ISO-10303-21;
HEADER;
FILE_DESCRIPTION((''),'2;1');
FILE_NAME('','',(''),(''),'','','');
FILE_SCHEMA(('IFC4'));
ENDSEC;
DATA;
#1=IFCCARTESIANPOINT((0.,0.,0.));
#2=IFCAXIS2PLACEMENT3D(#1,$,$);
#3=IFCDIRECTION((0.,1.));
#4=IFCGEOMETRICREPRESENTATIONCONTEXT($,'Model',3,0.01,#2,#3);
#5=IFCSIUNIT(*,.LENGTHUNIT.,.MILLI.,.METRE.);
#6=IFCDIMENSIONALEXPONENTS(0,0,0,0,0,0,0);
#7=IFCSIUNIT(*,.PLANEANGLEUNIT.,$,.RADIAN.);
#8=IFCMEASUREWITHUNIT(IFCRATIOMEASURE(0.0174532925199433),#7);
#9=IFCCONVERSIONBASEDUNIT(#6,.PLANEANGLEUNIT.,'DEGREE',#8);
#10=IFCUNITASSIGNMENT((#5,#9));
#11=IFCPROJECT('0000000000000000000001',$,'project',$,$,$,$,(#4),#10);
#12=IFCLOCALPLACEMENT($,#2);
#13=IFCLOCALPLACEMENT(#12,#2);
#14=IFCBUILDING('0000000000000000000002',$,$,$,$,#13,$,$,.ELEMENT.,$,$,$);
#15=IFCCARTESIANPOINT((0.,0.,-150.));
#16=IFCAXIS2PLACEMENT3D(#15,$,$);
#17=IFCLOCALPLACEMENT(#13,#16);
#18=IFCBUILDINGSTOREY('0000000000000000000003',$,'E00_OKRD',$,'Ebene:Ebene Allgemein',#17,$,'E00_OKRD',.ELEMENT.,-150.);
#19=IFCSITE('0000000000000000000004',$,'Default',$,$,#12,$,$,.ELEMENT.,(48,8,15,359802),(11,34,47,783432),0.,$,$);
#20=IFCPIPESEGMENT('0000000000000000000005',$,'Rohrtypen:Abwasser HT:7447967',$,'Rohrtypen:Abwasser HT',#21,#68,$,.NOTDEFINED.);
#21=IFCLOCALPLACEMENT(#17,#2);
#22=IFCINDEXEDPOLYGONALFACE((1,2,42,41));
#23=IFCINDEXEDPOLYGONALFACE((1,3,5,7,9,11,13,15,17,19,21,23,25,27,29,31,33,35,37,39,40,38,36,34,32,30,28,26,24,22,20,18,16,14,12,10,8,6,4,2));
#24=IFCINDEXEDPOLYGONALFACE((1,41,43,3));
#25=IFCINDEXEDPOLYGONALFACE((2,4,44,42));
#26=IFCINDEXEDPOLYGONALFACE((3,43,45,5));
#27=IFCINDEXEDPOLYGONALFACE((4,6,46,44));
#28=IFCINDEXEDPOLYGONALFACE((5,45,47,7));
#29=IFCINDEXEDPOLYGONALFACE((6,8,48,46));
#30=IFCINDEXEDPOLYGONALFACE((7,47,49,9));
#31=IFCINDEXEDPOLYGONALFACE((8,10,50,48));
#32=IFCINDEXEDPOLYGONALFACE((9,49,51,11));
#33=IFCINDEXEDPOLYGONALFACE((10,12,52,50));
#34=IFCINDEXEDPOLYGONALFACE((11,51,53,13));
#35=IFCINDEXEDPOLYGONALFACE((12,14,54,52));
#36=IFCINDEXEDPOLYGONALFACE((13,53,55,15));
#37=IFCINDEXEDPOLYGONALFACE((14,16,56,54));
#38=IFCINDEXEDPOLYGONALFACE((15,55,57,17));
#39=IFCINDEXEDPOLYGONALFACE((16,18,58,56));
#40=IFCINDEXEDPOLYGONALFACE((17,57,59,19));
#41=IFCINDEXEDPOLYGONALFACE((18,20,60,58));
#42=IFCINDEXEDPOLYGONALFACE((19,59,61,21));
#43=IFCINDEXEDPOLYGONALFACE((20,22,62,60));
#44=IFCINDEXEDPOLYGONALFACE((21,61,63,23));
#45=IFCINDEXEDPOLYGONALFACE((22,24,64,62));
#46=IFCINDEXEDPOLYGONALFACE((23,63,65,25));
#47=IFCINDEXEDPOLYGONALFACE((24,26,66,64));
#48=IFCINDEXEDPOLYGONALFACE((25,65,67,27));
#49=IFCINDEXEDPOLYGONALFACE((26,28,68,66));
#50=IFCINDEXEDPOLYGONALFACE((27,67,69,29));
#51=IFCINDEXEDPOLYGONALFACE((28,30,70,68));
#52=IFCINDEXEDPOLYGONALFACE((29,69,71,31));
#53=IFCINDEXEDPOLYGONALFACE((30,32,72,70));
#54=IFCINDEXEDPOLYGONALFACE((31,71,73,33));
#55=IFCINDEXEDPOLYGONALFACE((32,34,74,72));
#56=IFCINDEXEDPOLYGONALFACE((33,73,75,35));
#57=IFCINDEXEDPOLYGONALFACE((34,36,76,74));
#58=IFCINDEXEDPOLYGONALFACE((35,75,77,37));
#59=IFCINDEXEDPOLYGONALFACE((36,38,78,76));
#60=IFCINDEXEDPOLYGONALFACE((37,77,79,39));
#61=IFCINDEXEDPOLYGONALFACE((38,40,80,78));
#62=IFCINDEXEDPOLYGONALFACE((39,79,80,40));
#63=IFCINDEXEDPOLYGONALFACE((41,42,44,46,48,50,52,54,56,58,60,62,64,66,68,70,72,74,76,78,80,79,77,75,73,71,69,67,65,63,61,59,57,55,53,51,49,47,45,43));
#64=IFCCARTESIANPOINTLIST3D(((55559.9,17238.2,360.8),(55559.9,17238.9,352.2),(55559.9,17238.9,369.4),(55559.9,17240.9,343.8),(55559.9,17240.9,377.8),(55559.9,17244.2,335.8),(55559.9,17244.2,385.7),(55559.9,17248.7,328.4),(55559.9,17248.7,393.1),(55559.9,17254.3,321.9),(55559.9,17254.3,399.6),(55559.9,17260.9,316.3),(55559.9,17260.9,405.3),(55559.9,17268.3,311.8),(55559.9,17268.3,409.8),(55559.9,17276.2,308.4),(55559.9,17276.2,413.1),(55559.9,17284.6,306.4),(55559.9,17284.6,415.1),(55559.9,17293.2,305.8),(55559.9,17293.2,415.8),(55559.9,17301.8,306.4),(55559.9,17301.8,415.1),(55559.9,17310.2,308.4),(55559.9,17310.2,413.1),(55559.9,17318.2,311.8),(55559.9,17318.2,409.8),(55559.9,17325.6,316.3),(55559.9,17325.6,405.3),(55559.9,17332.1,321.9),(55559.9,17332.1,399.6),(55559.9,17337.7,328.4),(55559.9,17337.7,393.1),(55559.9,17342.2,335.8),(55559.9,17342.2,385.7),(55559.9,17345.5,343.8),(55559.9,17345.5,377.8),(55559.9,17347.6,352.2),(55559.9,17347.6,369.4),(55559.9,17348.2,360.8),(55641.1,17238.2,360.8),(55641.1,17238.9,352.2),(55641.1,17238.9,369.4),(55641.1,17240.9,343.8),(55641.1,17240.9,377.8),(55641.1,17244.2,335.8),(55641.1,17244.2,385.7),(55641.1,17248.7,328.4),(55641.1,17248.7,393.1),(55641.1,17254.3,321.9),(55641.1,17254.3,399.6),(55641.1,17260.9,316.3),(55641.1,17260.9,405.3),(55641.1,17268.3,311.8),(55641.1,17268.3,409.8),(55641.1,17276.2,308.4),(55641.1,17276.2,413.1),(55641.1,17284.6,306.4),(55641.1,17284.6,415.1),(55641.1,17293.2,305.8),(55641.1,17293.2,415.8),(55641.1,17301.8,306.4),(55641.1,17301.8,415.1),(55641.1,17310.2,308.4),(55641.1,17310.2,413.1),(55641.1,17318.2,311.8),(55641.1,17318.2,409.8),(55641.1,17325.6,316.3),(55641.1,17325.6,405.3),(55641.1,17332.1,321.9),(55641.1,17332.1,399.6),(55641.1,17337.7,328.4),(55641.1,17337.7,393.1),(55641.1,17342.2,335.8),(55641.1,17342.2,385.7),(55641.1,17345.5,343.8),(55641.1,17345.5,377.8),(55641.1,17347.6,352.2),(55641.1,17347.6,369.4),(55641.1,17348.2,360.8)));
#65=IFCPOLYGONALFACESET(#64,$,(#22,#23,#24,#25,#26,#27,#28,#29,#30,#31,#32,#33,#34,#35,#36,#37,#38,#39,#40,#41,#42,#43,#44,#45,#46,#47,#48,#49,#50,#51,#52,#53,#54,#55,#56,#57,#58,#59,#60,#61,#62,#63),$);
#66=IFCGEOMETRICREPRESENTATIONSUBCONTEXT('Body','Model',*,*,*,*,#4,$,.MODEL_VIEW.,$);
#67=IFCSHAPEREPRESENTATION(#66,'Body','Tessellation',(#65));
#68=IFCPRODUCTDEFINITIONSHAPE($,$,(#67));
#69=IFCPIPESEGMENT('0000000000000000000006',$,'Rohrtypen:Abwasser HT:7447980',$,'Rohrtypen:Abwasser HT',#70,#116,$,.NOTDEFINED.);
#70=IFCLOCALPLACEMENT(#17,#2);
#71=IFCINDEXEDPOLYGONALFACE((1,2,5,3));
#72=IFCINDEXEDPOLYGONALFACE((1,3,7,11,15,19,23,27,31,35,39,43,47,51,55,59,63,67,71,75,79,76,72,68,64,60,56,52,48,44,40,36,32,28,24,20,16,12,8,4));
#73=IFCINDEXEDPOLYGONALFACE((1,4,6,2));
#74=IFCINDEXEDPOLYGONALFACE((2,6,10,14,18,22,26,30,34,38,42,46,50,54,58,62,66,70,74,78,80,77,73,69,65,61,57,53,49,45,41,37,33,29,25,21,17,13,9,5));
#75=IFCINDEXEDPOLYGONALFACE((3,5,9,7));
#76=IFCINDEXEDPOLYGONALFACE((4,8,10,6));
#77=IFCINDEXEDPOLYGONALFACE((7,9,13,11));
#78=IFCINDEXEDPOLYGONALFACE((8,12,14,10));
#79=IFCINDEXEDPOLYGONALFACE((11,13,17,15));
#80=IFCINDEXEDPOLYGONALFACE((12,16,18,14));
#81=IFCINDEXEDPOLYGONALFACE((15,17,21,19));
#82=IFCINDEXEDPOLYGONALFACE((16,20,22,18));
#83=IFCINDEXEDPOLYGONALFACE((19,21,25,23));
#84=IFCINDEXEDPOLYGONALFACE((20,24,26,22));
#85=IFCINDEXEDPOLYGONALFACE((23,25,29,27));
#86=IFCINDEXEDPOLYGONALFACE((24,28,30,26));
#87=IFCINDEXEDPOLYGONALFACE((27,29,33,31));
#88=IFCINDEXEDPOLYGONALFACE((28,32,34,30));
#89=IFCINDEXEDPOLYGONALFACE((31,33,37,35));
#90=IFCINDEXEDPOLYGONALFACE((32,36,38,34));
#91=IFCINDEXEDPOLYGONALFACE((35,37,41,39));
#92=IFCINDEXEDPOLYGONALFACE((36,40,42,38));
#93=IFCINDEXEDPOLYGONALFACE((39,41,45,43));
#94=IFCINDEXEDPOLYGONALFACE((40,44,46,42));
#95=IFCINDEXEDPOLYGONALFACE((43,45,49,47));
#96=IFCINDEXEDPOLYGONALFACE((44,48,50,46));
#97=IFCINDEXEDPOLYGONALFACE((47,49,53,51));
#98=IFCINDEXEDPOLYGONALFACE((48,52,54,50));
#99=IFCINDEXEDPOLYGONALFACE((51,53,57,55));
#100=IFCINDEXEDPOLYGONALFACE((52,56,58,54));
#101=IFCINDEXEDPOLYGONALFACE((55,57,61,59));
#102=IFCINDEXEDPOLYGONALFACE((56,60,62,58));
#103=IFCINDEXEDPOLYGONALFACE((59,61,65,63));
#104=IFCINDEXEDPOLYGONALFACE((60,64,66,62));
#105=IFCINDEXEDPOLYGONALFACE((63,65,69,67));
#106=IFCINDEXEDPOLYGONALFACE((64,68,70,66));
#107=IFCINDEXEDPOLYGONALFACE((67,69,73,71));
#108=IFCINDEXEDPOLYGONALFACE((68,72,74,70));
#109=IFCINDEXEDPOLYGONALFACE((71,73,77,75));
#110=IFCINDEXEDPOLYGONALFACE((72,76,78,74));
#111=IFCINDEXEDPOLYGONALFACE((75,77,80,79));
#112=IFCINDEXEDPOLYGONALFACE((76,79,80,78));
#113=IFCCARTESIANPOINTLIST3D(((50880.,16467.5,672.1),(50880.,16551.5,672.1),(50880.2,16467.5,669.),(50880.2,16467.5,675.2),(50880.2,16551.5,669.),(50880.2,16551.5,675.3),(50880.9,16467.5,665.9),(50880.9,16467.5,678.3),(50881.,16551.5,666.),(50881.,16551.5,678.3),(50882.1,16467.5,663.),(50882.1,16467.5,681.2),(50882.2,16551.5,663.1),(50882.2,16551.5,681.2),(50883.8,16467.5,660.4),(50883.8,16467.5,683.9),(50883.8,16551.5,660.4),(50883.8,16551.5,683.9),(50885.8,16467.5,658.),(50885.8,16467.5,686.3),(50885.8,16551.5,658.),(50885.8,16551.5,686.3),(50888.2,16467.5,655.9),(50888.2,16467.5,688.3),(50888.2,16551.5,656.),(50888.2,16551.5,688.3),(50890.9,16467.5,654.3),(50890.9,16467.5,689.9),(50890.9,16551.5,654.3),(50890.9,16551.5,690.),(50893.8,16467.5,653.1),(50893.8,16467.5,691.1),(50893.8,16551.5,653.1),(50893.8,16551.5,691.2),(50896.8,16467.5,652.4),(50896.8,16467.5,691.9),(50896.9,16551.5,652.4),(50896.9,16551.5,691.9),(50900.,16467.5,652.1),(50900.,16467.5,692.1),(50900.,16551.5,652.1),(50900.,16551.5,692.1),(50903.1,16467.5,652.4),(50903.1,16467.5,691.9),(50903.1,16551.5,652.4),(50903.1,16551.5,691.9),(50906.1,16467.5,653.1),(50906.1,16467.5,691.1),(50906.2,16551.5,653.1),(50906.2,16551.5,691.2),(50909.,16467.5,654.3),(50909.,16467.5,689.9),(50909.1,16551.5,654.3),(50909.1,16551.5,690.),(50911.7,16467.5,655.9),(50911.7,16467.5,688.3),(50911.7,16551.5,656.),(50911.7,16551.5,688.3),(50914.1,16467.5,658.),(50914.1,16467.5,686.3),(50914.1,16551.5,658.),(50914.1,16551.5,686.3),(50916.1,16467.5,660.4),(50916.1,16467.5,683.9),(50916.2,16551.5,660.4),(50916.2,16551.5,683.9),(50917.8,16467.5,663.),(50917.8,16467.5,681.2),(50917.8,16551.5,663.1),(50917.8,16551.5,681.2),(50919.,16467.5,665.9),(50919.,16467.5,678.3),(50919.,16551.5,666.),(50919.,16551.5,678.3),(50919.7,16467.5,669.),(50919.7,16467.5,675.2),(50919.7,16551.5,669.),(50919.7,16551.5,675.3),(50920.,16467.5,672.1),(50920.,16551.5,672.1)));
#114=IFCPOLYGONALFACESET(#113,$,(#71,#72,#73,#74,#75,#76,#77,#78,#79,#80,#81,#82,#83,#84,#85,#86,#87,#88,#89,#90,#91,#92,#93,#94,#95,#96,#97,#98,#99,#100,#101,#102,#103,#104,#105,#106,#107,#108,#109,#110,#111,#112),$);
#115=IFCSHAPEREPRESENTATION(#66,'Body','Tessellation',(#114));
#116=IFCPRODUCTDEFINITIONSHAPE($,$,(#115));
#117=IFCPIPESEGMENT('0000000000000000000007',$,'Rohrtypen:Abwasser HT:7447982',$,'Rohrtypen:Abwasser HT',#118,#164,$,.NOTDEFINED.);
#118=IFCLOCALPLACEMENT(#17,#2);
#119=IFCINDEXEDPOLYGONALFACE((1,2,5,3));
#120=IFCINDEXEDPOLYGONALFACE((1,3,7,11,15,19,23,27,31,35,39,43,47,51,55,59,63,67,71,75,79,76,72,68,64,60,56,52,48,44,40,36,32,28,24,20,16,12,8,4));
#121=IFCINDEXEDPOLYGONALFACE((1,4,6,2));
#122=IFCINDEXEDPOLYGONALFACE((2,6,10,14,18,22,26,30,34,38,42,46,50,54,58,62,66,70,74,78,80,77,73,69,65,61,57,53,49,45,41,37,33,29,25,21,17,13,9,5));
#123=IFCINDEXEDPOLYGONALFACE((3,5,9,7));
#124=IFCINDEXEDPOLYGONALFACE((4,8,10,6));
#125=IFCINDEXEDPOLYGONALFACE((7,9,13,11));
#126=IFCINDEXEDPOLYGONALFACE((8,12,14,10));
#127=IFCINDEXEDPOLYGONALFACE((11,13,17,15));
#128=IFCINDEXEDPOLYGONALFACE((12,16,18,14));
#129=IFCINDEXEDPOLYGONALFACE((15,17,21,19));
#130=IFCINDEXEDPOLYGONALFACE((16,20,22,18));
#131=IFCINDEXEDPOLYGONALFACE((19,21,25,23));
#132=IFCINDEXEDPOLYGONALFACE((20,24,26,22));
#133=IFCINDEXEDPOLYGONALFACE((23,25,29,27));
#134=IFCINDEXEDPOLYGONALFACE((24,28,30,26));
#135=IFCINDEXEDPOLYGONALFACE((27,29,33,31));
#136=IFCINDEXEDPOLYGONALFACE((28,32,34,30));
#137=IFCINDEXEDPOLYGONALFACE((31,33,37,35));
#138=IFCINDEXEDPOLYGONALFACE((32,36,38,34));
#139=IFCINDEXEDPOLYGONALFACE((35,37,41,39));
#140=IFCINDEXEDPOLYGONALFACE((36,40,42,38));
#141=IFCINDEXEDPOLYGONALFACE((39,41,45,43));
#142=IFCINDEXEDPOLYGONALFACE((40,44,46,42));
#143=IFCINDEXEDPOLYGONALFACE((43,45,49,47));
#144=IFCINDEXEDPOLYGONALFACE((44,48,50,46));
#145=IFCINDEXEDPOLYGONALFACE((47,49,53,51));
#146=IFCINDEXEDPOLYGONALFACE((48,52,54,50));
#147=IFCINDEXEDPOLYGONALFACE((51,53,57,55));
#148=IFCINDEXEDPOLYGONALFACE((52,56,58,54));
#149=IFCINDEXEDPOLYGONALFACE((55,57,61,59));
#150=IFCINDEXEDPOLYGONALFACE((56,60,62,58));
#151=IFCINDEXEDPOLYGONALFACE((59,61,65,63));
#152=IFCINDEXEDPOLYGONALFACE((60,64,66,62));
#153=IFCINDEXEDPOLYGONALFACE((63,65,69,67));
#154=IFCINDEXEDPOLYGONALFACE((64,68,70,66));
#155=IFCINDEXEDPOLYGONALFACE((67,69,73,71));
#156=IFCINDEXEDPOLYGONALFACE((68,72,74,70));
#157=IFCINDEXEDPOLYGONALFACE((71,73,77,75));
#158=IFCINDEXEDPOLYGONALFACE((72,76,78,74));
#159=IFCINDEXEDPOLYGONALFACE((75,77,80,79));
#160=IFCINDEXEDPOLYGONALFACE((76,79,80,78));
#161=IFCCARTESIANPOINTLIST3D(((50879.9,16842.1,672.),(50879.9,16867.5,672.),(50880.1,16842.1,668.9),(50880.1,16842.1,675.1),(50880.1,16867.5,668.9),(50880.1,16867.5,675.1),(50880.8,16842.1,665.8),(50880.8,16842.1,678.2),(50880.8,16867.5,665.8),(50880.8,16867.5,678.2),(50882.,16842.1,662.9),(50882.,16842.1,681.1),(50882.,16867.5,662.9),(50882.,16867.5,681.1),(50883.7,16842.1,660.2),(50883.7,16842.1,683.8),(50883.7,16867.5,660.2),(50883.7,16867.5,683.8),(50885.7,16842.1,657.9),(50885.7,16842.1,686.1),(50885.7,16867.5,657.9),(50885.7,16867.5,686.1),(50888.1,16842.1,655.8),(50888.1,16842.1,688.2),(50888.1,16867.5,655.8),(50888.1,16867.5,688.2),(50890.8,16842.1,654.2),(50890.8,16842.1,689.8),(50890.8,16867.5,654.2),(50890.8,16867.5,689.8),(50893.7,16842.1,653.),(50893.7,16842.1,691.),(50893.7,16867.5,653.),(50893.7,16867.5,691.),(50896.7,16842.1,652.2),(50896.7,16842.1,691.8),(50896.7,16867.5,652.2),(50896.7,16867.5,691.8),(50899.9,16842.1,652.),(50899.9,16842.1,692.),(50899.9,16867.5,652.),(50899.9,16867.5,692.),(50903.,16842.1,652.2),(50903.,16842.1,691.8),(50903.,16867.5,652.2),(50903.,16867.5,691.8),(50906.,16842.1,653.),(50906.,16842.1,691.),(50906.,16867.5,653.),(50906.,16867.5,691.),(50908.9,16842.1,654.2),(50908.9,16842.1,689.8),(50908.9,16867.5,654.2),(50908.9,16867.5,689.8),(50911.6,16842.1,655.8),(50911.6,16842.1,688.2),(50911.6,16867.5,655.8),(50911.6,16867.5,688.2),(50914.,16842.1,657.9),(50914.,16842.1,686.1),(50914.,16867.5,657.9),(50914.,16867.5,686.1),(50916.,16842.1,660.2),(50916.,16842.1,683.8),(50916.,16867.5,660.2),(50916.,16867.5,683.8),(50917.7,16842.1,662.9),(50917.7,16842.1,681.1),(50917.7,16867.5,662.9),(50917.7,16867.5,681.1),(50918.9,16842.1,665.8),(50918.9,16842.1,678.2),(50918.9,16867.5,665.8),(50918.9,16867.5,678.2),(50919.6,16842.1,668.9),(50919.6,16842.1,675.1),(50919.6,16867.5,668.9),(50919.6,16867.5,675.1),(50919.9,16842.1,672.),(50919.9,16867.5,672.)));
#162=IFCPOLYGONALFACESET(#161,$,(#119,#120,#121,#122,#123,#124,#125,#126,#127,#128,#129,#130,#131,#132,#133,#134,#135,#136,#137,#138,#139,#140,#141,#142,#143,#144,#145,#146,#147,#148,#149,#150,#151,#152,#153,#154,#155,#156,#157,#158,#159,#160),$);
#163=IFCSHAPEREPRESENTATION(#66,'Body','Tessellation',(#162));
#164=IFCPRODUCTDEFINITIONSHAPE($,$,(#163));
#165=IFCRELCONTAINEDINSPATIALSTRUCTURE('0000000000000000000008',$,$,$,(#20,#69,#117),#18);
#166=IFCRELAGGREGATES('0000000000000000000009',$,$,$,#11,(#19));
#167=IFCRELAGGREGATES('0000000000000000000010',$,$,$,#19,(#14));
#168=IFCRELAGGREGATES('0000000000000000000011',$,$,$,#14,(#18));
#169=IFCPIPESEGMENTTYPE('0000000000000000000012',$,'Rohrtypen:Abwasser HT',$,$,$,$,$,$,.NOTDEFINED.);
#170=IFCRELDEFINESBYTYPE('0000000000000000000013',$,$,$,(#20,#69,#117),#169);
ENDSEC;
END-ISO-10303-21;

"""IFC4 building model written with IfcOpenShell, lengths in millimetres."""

from ifc_helpers import new_model, entity, si_unit, converted_unit, direction, frame, origin, place, context, subcontext, project, spatial, indexed_curve, outline, extrude, type_object, element, save


model = new_model("IFC4")

# Units and contexts
model_context = context("Model", 3, precision=0.01, world=origin(), true_north=direction((0.0, 1.0)))
body_context = subcontext(model_context, "Body", "Model", "MODEL_VIEW")
ifc_project = project(units=[si_unit("LENGTHUNIT", "METRE", prefix="MILLI"), converted_unit("PLANEANGLEUNIT", "DEGREE", entity("IfcRatioMeasure", 0.0174532925199433), si_unit("PLANEANGLEUNIT", "RADIAN"), dimensions=[0, 0, 0, 0, 0, 0, 0])], contexts=[model_context])

# Site, building, storey
site_placement = place(None, origin())
site = spatial("IfcSite", under=ifc_project, at=site_placement, Name="Default", CompositionType="ELEMENT", RefLatitude=(48, 8, 15, 359802), RefLongitude=(11, 34, 47, 783432), RefElevation=0.0)
building_placement = place(site_placement, origin())
building = spatial("IfcBuilding", under=site, at=building_placement, CompositionType="ELEMENT")
storey_placement = place(building_placement, frame((0.0, 0.0, -150.0)))
storey = spatial("IfcBuildingStorey", under=building, at=storey_placement, Name="E00_OKRD", ObjectType="Ebene:Ebene Allgemein", LongName="E00_OKRD", CompositionType="ELEMENT", Elevation=-150.0)

# Pipe segments
pipe_segment_type_1 = type_object("IfcPipeSegmentType", Name="Rohrtypen:Abwasser HT", PredefinedType="NOTDEFINED")
pipe_segment_1_placement = place(storey_placement, origin())
element("IfcPipeSegment", 1, at=pipe_segment_1_placement, inside=storey, type_object=pipe_segment_type_1, Name="Rohrtypen:Abwasser HT:7447967", ObjectType="Rohrtypen:Abwasser HT", PredefinedType="NOTDEFINED", context=body_context, shape_type="SweptSolid", body=[
    extrude(outline(indexed_curve([(55.0, 0.0), (54.3, 8.6), (52.3, 17.0), (49.0, 25.0), (44.5, 32.3), (38.9, 38.9), (32.3, 44.5), (25.0, 49.0), (17.0, 52.3), (8.6, 54.3), (0.0, 55.0), (-8.6, 54.3), (-17.0, 52.3), (-25.0, 49.0), (-32.3, 44.5), (-38.9, 38.9), (-44.5, 32.3), (-49.0, 25.0), (-52.3, 17.0), (-54.3, 8.6), (-55.0, 0.0), (-54.3, -8.6), (-52.3, -17.0), (-49.0, -25.0), (-44.5, -32.3), (-38.9, -38.9), (-32.3, -44.5), (-25.0, -49.0), (-17.0, -52.3), (-8.6, -54.3), (0.0, -55.0), (8.6, -54.3), (17.0, -52.3), (25.0, -49.0), (32.3, -44.5), (38.9, -38.9), (44.5, -32.3), (49.0, -25.0), (52.3, -17.0), (54.3, -8.6), (55.0, 0.0)], self_intersect=False)), frame((55559.9, 17293.2, 360.8), z_axis=(1.0, 0.0, 0.0), x_axis=(0.0, -1.0, 0.0)), (0.0, 0.0, 1.0), 81.3),
])
pipe_segment_2_placement = place(storey_placement, origin())
element("IfcPipeSegment", 2, at=pipe_segment_2_placement, inside=storey, type_object=pipe_segment_type_1, Name="Rohrtypen:Abwasser HT:7447980", ObjectType="Rohrtypen:Abwasser HT", PredefinedType="NOTDEFINED", context=body_context, shape_type="SweptSolid", body=[
    extrude(outline(indexed_curve([(20.0, 0.0), (19.8, 3.1), (19.0, 6.2), (17.8, 9.1), (16.2, 11.8), (14.1, 14.1), (11.8, 16.2), (9.1, 17.8), (6.2, 19.0), (3.1, 19.8), (0.0, 20.0), (-3.1, 19.8), (-6.2, 19.0), (-9.1, 17.8), (-11.8, 16.2), (-14.1, 14.1), (-16.2, 11.8), (-17.8, 9.1), (-19.0, 6.2), (-19.8, 3.1), (-20.0, 0.0), (-19.8, -3.1), (-19.0, -6.2), (-17.8, -9.1), (-16.2, -11.8), (-14.1, -14.1), (-11.8, -16.2), (-9.1, -17.8), (-6.2, -19.0), (-3.1, -19.8), (0.0, -20.0), (3.1, -19.8), (6.2, -19.0), (9.1, -17.8), (11.8, -16.2), (14.1, -14.1), (16.2, -11.8), (17.8, -9.1), (19.0, -6.2), (19.8, -3.1), (20.0, 0.0)], self_intersect=False)), frame((50900.0, 16467.5, 672.1), z_axis=(0.00027, 1.0, 0.00027), x_axis=(1.0, -0.00027, 0.0)), (0.0, 0.0, 1.0), 84.0),
])
pipe_segment_3_placement = place(storey_placement, origin())
element("IfcPipeSegment", 3, at=pipe_segment_3_placement, inside=storey, type_object=pipe_segment_type_1, Name="Rohrtypen:Abwasser HT:7447982", ObjectType="Rohrtypen:Abwasser HT", PredefinedType="NOTDEFINED", context=body_context, shape_type="SweptSolid", body=[
    extrude(outline(indexed_curve([(20.0, 0.0), (19.8, 3.1), (19.0, 6.2), (17.8, 9.1), (16.2, 11.8), (14.1, 14.1), (11.8, 16.2), (9.1, 17.8), (6.2, 19.0), (3.1, 19.8), (0.0, 20.0), (-3.1, 19.8), (-6.2, 19.0), (-9.1, 17.8), (-11.8, 16.2), (-14.1, 14.1), (-16.2, 11.8), (-17.8, 9.1), (-19.0, 6.2), (-19.8, 3.1), (-20.0, 0.0), (-19.8, -3.1), (-19.0, -6.2), (-17.8, -9.1), (-16.2, -11.8), (-14.1, -14.1), (-11.8, -16.2), (-9.1, -17.8), (-6.2, -19.0), (-3.1, -19.8), (0.0, -20.0), (3.1, -19.8), (6.2, -19.0), (9.1, -17.8), (11.8, -16.2), (14.1, -14.1), (16.2, -11.8), (17.8, -9.1), (19.0, -6.2), (19.8, -3.1), (20.0, 0.0)], self_intersect=False)), frame((50899.9, 16842.1, 672.0), z_axis=(0.0, 1.0, 0.0), x_axis=(-1.0, 0.0, 0.0)), (0.0, 0.0, 1.0), 25.5),
])

save(model, "model.ifc")
